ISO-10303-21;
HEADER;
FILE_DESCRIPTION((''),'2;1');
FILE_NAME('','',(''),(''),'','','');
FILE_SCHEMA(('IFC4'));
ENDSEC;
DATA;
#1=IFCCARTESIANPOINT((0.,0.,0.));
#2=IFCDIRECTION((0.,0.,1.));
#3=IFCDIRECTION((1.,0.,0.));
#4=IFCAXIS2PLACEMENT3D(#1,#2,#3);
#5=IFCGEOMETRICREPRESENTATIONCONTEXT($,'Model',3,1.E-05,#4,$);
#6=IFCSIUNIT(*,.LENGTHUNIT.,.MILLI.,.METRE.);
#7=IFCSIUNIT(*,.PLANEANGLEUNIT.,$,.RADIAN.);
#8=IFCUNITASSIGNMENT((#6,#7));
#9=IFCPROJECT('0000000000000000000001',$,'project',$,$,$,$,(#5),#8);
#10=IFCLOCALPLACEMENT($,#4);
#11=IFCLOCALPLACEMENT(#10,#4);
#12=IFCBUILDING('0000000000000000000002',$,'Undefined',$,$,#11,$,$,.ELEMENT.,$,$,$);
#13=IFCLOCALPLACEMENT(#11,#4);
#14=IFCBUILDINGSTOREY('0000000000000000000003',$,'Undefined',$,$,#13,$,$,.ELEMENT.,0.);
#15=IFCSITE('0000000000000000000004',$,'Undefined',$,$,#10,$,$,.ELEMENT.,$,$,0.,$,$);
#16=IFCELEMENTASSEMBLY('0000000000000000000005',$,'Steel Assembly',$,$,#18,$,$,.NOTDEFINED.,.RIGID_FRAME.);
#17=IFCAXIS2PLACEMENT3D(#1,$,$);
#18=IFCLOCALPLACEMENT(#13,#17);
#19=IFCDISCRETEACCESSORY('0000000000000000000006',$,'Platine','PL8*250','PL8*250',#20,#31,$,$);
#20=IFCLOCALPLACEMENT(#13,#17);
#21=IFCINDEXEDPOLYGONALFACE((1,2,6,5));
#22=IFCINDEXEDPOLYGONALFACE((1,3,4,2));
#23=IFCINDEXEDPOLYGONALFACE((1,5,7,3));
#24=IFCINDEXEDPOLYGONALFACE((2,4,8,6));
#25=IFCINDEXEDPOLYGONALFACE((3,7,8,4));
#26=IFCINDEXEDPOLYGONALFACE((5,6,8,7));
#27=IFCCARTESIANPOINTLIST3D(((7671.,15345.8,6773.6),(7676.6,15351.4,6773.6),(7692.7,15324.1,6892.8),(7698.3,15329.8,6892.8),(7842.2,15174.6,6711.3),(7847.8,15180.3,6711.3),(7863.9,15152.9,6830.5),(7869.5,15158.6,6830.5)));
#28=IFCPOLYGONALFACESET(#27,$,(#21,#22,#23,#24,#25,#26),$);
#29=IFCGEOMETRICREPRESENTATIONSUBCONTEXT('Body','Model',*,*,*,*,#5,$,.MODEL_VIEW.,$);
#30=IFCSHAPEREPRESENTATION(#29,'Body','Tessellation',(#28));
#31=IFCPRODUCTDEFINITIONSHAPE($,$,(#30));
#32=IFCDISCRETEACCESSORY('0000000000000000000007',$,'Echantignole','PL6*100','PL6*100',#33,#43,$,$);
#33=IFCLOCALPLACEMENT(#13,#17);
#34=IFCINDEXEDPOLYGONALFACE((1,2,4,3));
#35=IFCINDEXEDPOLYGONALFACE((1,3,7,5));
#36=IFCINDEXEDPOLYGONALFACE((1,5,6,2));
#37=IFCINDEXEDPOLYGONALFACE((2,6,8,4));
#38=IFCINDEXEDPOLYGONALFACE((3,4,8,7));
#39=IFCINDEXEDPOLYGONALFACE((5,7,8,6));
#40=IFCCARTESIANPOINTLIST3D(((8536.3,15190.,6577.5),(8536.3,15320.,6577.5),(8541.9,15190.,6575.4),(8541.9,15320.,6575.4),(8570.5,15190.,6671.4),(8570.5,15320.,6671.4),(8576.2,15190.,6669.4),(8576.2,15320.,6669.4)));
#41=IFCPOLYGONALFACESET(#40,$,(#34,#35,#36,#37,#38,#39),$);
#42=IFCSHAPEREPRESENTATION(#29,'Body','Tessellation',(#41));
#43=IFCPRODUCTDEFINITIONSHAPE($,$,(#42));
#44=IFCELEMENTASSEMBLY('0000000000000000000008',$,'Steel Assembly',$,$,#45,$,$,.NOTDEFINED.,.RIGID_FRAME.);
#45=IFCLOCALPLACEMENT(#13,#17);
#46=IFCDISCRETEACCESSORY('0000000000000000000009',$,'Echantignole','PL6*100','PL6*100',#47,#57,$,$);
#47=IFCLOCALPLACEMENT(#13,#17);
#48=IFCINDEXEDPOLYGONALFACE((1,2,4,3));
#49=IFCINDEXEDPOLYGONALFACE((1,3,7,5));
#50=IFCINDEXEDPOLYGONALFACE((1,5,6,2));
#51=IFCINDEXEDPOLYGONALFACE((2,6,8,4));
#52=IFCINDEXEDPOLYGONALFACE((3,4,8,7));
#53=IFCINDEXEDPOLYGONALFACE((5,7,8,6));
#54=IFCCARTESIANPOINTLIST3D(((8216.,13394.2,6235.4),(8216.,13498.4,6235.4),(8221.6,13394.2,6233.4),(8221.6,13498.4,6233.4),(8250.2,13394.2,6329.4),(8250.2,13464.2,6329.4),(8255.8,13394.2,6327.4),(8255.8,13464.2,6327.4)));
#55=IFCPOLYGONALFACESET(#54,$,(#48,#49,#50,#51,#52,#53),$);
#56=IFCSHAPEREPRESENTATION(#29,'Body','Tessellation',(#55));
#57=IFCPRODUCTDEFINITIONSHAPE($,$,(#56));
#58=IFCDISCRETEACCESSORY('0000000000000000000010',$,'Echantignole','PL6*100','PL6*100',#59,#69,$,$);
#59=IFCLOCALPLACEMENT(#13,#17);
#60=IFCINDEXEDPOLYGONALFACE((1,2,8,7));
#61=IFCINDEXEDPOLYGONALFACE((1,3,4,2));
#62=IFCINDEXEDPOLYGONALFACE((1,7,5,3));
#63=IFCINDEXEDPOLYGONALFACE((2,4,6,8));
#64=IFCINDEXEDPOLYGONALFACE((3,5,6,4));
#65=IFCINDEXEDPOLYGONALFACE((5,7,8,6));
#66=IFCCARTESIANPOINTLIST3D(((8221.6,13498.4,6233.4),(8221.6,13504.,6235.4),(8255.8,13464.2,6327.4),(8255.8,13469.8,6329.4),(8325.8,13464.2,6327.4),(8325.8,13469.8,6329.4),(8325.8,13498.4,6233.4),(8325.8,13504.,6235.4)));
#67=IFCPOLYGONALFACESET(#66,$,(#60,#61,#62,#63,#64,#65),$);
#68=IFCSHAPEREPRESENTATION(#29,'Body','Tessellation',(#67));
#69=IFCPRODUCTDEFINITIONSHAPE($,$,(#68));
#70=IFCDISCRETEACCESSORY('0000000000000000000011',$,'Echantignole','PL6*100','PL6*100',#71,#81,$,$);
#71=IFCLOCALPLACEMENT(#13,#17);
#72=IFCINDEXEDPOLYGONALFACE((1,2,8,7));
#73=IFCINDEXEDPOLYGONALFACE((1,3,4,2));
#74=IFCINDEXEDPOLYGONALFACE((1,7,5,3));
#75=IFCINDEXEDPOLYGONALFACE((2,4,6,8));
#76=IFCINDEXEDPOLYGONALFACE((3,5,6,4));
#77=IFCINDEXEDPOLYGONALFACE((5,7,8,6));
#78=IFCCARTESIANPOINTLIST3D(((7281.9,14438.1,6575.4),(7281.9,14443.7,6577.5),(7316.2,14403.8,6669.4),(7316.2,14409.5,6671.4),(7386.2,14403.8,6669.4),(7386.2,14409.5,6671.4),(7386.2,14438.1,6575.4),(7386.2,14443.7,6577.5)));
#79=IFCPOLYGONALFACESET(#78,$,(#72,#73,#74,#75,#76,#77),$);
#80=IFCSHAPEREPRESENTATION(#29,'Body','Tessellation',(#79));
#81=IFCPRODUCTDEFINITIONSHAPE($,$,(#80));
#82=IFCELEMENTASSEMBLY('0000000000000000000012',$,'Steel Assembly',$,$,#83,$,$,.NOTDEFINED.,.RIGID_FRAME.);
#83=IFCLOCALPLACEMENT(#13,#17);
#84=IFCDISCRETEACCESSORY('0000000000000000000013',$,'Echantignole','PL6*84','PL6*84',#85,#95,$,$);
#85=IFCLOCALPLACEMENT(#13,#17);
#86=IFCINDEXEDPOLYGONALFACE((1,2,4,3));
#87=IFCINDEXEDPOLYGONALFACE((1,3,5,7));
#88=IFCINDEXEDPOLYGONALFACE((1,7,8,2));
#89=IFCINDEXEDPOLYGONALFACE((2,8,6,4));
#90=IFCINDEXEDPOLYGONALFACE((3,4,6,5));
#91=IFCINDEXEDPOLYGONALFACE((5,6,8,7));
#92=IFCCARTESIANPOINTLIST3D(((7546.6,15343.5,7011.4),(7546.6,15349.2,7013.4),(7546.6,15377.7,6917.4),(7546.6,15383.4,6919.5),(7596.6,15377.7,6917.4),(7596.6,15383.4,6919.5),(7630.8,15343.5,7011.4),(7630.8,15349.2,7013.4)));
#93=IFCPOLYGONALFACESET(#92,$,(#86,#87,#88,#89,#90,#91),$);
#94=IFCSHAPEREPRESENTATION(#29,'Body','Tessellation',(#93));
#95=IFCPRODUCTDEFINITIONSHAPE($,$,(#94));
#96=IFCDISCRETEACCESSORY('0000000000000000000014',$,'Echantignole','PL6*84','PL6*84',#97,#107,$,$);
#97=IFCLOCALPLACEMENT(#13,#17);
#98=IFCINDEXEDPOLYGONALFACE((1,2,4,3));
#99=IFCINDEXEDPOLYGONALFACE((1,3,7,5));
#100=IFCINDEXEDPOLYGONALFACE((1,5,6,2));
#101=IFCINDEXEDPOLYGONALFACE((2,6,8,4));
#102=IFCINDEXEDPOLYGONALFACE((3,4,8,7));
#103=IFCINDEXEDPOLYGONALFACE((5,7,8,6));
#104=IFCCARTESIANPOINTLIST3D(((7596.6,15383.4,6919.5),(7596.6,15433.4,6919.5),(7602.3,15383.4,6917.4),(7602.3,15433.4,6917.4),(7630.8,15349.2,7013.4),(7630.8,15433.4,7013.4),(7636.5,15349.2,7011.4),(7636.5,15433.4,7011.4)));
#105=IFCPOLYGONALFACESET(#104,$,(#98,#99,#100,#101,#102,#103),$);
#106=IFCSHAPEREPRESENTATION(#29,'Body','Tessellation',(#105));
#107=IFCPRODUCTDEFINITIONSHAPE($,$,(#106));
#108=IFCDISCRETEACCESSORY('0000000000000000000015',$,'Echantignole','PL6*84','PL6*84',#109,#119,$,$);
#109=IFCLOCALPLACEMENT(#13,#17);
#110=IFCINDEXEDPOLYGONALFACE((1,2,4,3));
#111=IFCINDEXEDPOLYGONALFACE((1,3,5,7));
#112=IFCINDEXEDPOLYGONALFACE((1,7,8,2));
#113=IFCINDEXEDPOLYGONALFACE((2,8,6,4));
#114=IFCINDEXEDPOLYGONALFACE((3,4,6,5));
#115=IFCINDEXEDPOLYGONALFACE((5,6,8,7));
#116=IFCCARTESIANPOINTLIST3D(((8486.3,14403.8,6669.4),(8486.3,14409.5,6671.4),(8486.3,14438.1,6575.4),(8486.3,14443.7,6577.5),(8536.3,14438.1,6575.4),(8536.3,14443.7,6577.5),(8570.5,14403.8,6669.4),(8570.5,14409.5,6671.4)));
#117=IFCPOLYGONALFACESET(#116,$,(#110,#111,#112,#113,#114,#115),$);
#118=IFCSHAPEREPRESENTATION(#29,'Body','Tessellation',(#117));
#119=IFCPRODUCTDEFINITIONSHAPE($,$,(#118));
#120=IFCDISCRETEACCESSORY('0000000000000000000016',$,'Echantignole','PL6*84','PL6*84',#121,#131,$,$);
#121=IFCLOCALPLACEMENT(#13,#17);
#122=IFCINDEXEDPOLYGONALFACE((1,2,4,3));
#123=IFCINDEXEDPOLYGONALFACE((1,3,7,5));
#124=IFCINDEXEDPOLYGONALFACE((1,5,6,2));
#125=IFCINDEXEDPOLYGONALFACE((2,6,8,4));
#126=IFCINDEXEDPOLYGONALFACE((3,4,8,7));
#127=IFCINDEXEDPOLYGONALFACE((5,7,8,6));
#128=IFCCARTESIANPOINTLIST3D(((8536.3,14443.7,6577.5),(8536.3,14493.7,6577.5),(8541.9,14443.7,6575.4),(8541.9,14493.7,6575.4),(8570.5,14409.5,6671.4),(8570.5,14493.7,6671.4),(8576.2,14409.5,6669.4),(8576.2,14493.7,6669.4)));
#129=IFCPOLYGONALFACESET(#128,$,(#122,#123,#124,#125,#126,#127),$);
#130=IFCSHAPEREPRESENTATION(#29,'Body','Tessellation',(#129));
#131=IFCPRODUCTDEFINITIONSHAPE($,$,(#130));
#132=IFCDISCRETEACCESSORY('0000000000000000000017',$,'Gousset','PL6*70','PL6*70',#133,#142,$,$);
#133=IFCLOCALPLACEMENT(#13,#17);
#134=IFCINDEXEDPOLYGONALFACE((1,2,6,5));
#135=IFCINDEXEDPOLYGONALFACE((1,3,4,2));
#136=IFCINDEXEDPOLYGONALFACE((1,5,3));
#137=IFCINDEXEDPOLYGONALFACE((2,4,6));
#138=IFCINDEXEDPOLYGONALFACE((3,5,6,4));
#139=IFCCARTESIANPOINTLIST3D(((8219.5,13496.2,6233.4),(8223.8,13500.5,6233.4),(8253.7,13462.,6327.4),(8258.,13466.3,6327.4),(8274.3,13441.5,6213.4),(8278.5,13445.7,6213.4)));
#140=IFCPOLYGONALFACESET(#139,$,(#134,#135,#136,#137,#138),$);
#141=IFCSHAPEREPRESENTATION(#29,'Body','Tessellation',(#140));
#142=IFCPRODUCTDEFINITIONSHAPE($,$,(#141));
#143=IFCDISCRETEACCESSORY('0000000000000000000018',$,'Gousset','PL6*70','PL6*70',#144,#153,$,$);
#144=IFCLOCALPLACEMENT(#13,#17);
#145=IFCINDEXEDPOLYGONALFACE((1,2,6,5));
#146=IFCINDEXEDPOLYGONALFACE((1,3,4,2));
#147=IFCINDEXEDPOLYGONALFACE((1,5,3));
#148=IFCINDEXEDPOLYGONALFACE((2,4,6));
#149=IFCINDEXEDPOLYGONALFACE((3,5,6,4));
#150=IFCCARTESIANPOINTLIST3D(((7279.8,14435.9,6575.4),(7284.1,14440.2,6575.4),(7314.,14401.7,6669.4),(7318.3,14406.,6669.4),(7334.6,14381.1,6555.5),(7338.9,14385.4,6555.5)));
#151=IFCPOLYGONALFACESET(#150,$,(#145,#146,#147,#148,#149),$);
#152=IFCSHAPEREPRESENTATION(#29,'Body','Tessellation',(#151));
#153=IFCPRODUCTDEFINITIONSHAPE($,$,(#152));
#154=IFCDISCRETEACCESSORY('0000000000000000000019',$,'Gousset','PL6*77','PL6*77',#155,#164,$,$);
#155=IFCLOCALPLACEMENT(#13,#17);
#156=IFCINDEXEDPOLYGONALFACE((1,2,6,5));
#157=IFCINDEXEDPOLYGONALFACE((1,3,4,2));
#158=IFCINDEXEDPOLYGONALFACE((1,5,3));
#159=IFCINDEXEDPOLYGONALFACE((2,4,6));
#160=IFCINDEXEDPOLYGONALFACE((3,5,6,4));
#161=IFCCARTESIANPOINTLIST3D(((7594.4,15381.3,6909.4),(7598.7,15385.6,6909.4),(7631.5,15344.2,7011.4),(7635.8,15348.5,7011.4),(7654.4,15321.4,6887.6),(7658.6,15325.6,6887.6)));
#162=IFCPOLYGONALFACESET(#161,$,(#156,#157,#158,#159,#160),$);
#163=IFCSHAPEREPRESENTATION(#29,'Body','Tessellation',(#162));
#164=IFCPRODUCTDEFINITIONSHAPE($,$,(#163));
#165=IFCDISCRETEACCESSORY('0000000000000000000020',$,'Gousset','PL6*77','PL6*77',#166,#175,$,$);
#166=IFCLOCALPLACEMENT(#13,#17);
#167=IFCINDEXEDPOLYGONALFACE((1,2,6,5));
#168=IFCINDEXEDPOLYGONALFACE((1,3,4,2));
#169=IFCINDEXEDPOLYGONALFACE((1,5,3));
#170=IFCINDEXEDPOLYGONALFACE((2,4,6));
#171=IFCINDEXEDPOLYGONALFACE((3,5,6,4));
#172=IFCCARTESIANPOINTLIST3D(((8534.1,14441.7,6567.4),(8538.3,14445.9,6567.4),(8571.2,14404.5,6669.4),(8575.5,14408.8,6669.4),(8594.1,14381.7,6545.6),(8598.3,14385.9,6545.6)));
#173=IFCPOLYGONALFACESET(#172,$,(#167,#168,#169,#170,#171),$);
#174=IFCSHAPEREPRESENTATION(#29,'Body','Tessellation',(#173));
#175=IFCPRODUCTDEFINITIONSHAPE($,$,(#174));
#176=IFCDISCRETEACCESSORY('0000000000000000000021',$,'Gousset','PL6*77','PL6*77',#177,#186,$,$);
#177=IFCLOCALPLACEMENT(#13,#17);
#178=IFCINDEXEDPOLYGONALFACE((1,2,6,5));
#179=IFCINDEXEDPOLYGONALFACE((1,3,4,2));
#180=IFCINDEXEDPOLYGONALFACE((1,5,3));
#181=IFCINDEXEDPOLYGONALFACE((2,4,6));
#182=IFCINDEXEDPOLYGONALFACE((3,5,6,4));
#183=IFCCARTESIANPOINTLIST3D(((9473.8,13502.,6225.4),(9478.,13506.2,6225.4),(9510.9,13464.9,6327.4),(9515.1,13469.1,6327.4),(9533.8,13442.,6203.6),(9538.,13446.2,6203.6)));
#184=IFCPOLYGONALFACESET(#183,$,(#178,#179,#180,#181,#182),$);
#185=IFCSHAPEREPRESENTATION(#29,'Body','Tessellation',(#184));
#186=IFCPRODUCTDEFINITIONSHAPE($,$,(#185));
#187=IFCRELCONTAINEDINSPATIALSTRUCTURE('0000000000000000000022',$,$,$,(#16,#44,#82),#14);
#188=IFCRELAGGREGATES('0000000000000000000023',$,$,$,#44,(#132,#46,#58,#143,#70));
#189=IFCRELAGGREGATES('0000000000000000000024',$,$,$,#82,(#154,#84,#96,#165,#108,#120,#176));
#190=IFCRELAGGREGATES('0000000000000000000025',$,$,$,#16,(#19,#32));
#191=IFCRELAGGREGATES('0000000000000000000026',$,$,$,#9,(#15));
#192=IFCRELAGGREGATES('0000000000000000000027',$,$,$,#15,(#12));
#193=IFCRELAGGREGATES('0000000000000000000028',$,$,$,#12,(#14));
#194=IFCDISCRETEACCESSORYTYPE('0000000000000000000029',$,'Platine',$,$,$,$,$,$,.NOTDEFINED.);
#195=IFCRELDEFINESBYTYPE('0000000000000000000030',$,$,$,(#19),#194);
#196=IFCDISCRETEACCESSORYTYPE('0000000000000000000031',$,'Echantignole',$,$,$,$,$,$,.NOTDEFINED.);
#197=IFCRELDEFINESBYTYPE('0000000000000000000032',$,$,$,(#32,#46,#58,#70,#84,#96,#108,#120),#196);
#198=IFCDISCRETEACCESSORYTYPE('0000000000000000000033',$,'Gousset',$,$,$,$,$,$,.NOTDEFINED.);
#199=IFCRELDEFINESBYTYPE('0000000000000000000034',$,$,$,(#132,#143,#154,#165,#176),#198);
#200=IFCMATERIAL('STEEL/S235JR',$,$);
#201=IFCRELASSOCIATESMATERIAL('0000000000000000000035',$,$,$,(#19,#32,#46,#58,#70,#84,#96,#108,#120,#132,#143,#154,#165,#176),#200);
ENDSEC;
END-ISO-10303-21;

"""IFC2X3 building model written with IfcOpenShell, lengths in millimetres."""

from ifc_helpers import new_model, si_unit, frame, origin_with_axes, origin_2d_with_axis, place, context, subcontext, project, spatial, polyline, rectangle, outline, extrude, material, type_object, element, aggregate, save


model = new_model("IFC2X3")

# Units and contexts
model_context = context("Model", 3, precision=1e-05, world=origin_with_axes())
body_context = subcontext(model_context, "Body", "Model", "MODEL_VIEW")
ifc_project = project(units=[si_unit("LENGTHUNIT", "METRE", prefix="MILLI"), si_unit("PLANEANGLEUNIT", "RADIAN")], contexts=[model_context])

# Site, building, storey
site_placement = place(None, origin_with_axes())
site = spatial("IfcSite", under=ifc_project, at=site_placement, Name="Undefined", CompositionType="ELEMENT", RefElevation=0.0)
building_placement = place(site_placement, origin_with_axes())
building = spatial("IfcBuilding", under=site, at=building_placement, Name="Undefined", CompositionType="ELEMENT")
storey_placement = place(building_placement, origin_with_axes())
storey = spatial("IfcBuildingStorey", under=building, at=storey_placement, Name="Undefined", CompositionType="ELEMENT", Elevation=0.0)

# Element assemblies, discrete accessories
assembly_1_placement = place(storey_placement, origin_with_axes())
assembly_1 = element("IfcElementAssembly", 1, at=assembly_1_placement, inside=storey, Name="Steel Assembly", AssemblyPlace="NOTDEFINED", PredefinedType="RIGID_FRAME")
ifc_material_1 = material(Name="STEEL/S235JR")
discrete_accessory_type_1 = type_object("IfcDiscreteAccessoryType", Name="Platine")
discrete_accessory_1_placement = place(assembly_1_placement, frame((7759.4, 15263.0, 6742.5), z_axis=(0.684794, -0.684788, -0.249244), x_axis=(0.176242, -0.176242, 0.968441)))
discrete_accessory_1 = element("IfcDiscreteAccessory", 2, at=discrete_accessory_1_placement, type_object=discrete_accessory_type_1, material=ifc_material_1, Name="Platine", Description="PL8*250", ObjectType="PL8*250", context=body_context, shape_type="SweptSolid", body=[
    extrude(rectangle(XDim=8.0, YDim=250.0, at=origin_2d_with_axis()), frame((123.1, 0.0, 0.0), z_axis=(-1.0, 0.0, 0.0), x_axis=(0.0, -1.0, 0.0)), (0.0, 0.0, 1.0), 123.1),
])
discrete_accessory_type_2 = type_object("IfcDiscreteAccessoryType", Name="Echantignole")
discrete_accessory_2_placement = place(assembly_1_placement, frame((8556.2, 15190.0, 6623.4), z_axis=(0.939693, 0.0, -0.34202), x_axis=(0.0, 1.0, 0.0)))
discrete_accessory_2 = element("IfcDiscreteAccessory", 3, at=discrete_accessory_2_placement, type_object=discrete_accessory_type_2, material=ifc_material_1, Name="Echantignole", Description="PL6*100", ObjectType="PL6*100", context=body_context, shape_type="SweptSolid", body=[
    extrude(outline(polyline([(0.0, 50.0), (130.0, 50.0), (130.0, -50.0), (0.0, -50.0), (0.0, 50.0)])), frame((0.0, 0.0, -3.0), z_axis=(0.0, 0.0, 1.0), x_axis=(1.0, 0.0, 0.0)), (0.0, 0.0, 1.0), 6.0),
])
assembly_2_placement = place(storey_placement, origin_with_axes())
assembly_2 = element("IfcElementAssembly", 4, at=assembly_2_placement, inside=storey, Name="Steel Assembly", AssemblyPlace="NOTDEFINED", PredefinedType="RIGID_FRAME")
discrete_accessory_3_placement = place(assembly_2_placement, frame((8253.0, 13464.2, 6328.4), z_axis=(0.939693, 0.0, -0.34202), x_axis=(0.0, -1.0, 0.0)))
discrete_accessory_3 = element("IfcDiscreteAccessory", 5, at=discrete_accessory_3_placement, type_object=discrete_accessory_type_2, material=ifc_material_1, Name="Echantignole", Description="PL6*100", ObjectType="PL6*100", context=body_context, shape_type="SweptSolid", body=[
    extrude(outline(polyline([(0.0, 0.0), (70.0, 0.0), (70.0, 100.0), (-34.2, 100.0), (0.0, 0.0)])), frame((0.0, 0.0, -3.0), z_axis=(0.0, 0.0, 1.0), x_axis=(1.0, 0.0, 0.0)), (0.0, 0.0, 1.0), 6.0),
])
discrete_accessory_4_placement = place(assembly_2_placement, frame((8255.8, 13467.0, 6328.4), z_axis=(0.0, 0.939693, 0.34202), x_axis=(1.0, 0.0, 0.0)))
discrete_accessory_4 = element("IfcDiscreteAccessory", 6, at=discrete_accessory_4_placement, type_object=discrete_accessory_type_2, material=ifc_material_1, Name="Echantignole", Description="PL6*100", ObjectType="PL6*100", context=body_context, shape_type="SweptSolid", body=[
    extrude(outline(polyline([(0.0, 0.0), (70.0, 0.0), (70.0, 100.0), (-34.2, 100.0), (0.0, 0.0)])), frame((0.0, 0.0, -3.0), z_axis=(0.0, 0.0, 1.0), x_axis=(1.0, 0.0, 0.0)), (0.0, 0.0, 1.0), 6.0),
])
discrete_accessory_5_placement = place(assembly_2_placement, frame((7316.2, 14406.7, 6670.4), z_axis=(0.0, 0.939693, 0.34202), x_axis=(1.0, 0.0, 0.0)))
discrete_accessory_5 = element("IfcDiscreteAccessory", 7, at=discrete_accessory_5_placement, type_object=discrete_accessory_type_2, material=ifc_material_1, Name="Echantignole", Description="PL6*100", ObjectType="PL6*100", context=body_context, shape_type="SweptSolid", body=[
    extrude(outline(polyline([(0.0, 0.0), (70.0, 0.0), (70.0, 100.0), (-34.2, 100.0), (0.0, 0.0)])), frame((0.0, 0.0, -3.0), z_axis=(0.0, 0.0, 1.0), x_axis=(1.0, 0.0, 0.0)), (0.0, 0.0, 1.0), 6.0),
])
assembly_3_placement = place(storey_placement, origin_with_axes())
assembly_3 = element("IfcElementAssembly", 8, at=assembly_3_placement, inside=storey, Name="Steel Assembly", AssemblyPlace="NOTDEFINED", PredefinedType="RIGID_FRAME")
discrete_accessory_6_placement = place(assembly_3_placement, frame((7596.6, 15380.6, 6918.5), z_axis=(0.0, 0.939693, 0.34202), x_axis=(-1.0, 0.0, 0.0)))
discrete_accessory_6 = element("IfcDiscreteAccessory", 9, at=discrete_accessory_6_placement, type_object=discrete_accessory_type_2, material=ifc_material_1, Name="Echantignole", Description="PL6*84", ObjectType="PL6*84", context=body_context, shape_type="SweptSolid", body=[
    extrude(outline(polyline([(0.0, 0.0), (50.0, 0.0), (50.0, 100.0), (-34.2, 100.0), (0.0, 0.0)])), frame((0.0, 0.0, -3.0), z_axis=(0.0, 0.0, 1.0), x_axis=(1.0, 0.0, 0.0)), (0.0, 0.0, 1.0), 6.0),
])
discrete_accessory_7_placement = place(assembly_3_placement, frame((7599.4, 15383.4, 6918.5), z_axis=(0.939693, 0.0, -0.34202), x_axis=(0.0, 1.0, 0.0)))
discrete_accessory_7 = element("IfcDiscreteAccessory", 10, at=discrete_accessory_7_placement, type_object=discrete_accessory_type_2, material=ifc_material_1, Name="Echantignole", Description="PL6*84", ObjectType="PL6*84", context=body_context, shape_type="SweptSolid", body=[
    extrude(outline(polyline([(0.0, 0.0), (50.0, 0.0), (50.0, 100.0), (-34.2, 100.0), (0.0, 0.0)])), frame((0.0, 0.0, -3.0), z_axis=(0.0, 0.0, 1.0), x_axis=(1.0, 0.0, 0.0)), (0.0, 0.0, 1.0), 6.0),
])
discrete_accessory_8_placement = place(assembly_3_placement, frame((8536.3, 14440.9, 6576.4), z_axis=(0.0, 0.939693, 0.34202), x_axis=(-1.0, 0.0, 0.0)))
discrete_accessory_8 = element("IfcDiscreteAccessory", 11, at=discrete_accessory_8_placement, type_object=discrete_accessory_type_2, material=ifc_material_1, Name="Echantignole", Description="PL6*84", ObjectType="PL6*84", context=body_context, shape_type="SweptSolid", body=[
    extrude(outline(polyline([(0.0, 0.0), (50.0, 0.0), (50.0, 100.0), (-34.2, 100.0), (0.0, 0.0)])), frame((0.0, 0.0, -3.0), z_axis=(0.0, 0.0, 1.0), x_axis=(1.0, 0.0, 0.0)), (0.0, 0.0, 1.0), 6.0),
])
discrete_accessory_9_placement = place(assembly_3_placement, frame((8539.1, 14443.7, 6576.4), z_axis=(0.939693, 0.0, -0.34202), x_axis=(0.0, 1.0, 0.0)))
discrete_accessory_9 = element("IfcDiscreteAccessory", 12, at=discrete_accessory_9_placement, type_object=discrete_accessory_type_2, material=ifc_material_1, Name="Echantignole", Description="PL6*84", ObjectType="PL6*84", context=body_context, shape_type="SweptSolid", body=[
    extrude(outline(polyline([(0.0, 0.0), (50.0, 0.0), (50.0, 100.0), (-34.2, 100.0), (0.0, 0.0)])), frame((0.0, 0.0, -3.0), z_axis=(0.0, 0.0, 1.0), x_axis=(1.0, 0.0, 0.0)), (0.0, 0.0, 1.0), 6.0),
])

# Discrete accessories
discrete_accessory_type_3 = type_object("IfcDiscreteAccessoryType", Name="Gousset")
discrete_accessory_10_placement = place(assembly_2_placement, frame((8255.8, 13464.2, 6327.4), z_axis=(-0.707107, -0.707107, 0.0), x_axis=(-0.323616, 0.323616, -0.889126)))
discrete_accessory_10 = element("IfcDiscreteAccessory", 13, at=discrete_accessory_10_placement, type_object=discrete_accessory_type_3, material=ifc_material_1, Name="Gousset", Description="PL6*70", ObjectType="PL6*70", context=body_context, shape_type="SweptSolid", body=[
    extrude(outline(polyline([(0.0, 0.0), (105.7, 0.0), (88.0, 78.0), (0.0, 0.0)])), frame((0.0, 0.0, -3.0), z_axis=(0.0, 0.0, 1.0), x_axis=(1.0, 0.0, 0.0)), (0.0, 0.0, 1.0), 6.0),
])
discrete_accessory_11_placement = place(assembly_2_placement, frame((7316.2, 14403.8, 6669.4), z_axis=(-0.707107, -0.707107, 0.0), x_axis=(-0.323616, 0.323616, -0.889126)))
discrete_accessory_11 = element("IfcDiscreteAccessory", 14, at=discrete_accessory_11_placement, type_object=discrete_accessory_type_3, material=ifc_material_1, Name="Gousset", Description="PL6*70", ObjectType="PL6*70", context=body_context, shape_type="SweptSolid", body=[
    extrude(outline(polyline([(0.0, 0.0), (105.7, 0.0), (88.0, 78.0), (0.0, 0.0)])), frame((0.0, 0.0, -3.0), z_axis=(0.0, 0.0, 1.0), x_axis=(1.0, 0.0, 0.0)), (0.0, 0.0, 1.0), 6.0),
])
aggregate(assembly_2, [discrete_accessory_10, discrete_accessory_3, discrete_accessory_4, discrete_accessory_11, discrete_accessory_5])
discrete_accessory_12_placement = place(assembly_3_placement, frame((7633.6, 15346.4, 7011.4), z_axis=(-0.707107, -0.707107, 0.0), x_axis=(-0.323616, 0.323616, -0.889126)))
discrete_accessory_12 = element("IfcDiscreteAccessory", 15, at=discrete_accessory_12_placement, type_object=discrete_accessory_type_3, material=ifc_material_1, Name="Gousset", Description="PL6*77", ObjectType="PL6*77", context=body_context, shape_type="SweptSolid", body=[
    extrude(outline(polyline([(0.0, 0.0), (114.7, 0.0), (95.3, 85.4), (0.0, 0.0)])), frame((0.0, 0.0, -3.0), z_axis=(0.0, 0.0, 1.0), x_axis=(1.0, 0.0, 0.0)), (0.0, 0.0, 1.0), 6.0),
])
discrete_accessory_13_placement = place(assembly_3_placement, frame((8573.3, 14406.7, 6669.4), z_axis=(-0.707107, -0.707107, 0.0), x_axis=(-0.323616, 0.323616, -0.889126)))
discrete_accessory_13 = element("IfcDiscreteAccessory", 16, at=discrete_accessory_13_placement, type_object=discrete_accessory_type_3, material=ifc_material_1, Name="Gousset", Description="PL6*77", ObjectType="PL6*77", context=body_context, shape_type="SweptSolid", body=[
    extrude(outline(polyline([(0.0, 0.0), (114.7, 0.0), (95.3, 85.4), (0.0, 0.0)])), frame((0.0, 0.0, -3.0), z_axis=(0.0, 0.0, 1.0), x_axis=(1.0, 0.0, 0.0)), (0.0, 0.0, 1.0), 6.0),
])
discrete_accessory_14_placement = place(assembly_3_placement, frame((9513.0, 13467.0, 6327.4), z_axis=(-0.707107, -0.707107, 0.0), x_axis=(-0.323616, 0.323616, -0.889126)))
discrete_accessory_14 = element("IfcDiscreteAccessory", 17, at=discrete_accessory_14_placement, type_object=discrete_accessory_type_3, material=ifc_material_1, Name="Gousset", Description="PL6*77", ObjectType="PL6*77", context=body_context, shape_type="SweptSolid", body=[
    extrude(outline(polyline([(0.0, 0.0), (114.7, 0.0), (95.3, 85.4), (0.0, 0.0)])), frame((0.0, 0.0, -3.0), z_axis=(0.0, 0.0, 1.0), x_axis=(1.0, 0.0, 0.0)), (0.0, 0.0, 1.0), 6.0),
])
aggregate(assembly_3, [discrete_accessory_12, discrete_accessory_6, discrete_accessory_7, discrete_accessory_13, discrete_accessory_8, discrete_accessory_9, discrete_accessory_14])

aggregate(assembly_1, [discrete_accessory_1, discrete_accessory_2])

save(model, "model.ifc")
